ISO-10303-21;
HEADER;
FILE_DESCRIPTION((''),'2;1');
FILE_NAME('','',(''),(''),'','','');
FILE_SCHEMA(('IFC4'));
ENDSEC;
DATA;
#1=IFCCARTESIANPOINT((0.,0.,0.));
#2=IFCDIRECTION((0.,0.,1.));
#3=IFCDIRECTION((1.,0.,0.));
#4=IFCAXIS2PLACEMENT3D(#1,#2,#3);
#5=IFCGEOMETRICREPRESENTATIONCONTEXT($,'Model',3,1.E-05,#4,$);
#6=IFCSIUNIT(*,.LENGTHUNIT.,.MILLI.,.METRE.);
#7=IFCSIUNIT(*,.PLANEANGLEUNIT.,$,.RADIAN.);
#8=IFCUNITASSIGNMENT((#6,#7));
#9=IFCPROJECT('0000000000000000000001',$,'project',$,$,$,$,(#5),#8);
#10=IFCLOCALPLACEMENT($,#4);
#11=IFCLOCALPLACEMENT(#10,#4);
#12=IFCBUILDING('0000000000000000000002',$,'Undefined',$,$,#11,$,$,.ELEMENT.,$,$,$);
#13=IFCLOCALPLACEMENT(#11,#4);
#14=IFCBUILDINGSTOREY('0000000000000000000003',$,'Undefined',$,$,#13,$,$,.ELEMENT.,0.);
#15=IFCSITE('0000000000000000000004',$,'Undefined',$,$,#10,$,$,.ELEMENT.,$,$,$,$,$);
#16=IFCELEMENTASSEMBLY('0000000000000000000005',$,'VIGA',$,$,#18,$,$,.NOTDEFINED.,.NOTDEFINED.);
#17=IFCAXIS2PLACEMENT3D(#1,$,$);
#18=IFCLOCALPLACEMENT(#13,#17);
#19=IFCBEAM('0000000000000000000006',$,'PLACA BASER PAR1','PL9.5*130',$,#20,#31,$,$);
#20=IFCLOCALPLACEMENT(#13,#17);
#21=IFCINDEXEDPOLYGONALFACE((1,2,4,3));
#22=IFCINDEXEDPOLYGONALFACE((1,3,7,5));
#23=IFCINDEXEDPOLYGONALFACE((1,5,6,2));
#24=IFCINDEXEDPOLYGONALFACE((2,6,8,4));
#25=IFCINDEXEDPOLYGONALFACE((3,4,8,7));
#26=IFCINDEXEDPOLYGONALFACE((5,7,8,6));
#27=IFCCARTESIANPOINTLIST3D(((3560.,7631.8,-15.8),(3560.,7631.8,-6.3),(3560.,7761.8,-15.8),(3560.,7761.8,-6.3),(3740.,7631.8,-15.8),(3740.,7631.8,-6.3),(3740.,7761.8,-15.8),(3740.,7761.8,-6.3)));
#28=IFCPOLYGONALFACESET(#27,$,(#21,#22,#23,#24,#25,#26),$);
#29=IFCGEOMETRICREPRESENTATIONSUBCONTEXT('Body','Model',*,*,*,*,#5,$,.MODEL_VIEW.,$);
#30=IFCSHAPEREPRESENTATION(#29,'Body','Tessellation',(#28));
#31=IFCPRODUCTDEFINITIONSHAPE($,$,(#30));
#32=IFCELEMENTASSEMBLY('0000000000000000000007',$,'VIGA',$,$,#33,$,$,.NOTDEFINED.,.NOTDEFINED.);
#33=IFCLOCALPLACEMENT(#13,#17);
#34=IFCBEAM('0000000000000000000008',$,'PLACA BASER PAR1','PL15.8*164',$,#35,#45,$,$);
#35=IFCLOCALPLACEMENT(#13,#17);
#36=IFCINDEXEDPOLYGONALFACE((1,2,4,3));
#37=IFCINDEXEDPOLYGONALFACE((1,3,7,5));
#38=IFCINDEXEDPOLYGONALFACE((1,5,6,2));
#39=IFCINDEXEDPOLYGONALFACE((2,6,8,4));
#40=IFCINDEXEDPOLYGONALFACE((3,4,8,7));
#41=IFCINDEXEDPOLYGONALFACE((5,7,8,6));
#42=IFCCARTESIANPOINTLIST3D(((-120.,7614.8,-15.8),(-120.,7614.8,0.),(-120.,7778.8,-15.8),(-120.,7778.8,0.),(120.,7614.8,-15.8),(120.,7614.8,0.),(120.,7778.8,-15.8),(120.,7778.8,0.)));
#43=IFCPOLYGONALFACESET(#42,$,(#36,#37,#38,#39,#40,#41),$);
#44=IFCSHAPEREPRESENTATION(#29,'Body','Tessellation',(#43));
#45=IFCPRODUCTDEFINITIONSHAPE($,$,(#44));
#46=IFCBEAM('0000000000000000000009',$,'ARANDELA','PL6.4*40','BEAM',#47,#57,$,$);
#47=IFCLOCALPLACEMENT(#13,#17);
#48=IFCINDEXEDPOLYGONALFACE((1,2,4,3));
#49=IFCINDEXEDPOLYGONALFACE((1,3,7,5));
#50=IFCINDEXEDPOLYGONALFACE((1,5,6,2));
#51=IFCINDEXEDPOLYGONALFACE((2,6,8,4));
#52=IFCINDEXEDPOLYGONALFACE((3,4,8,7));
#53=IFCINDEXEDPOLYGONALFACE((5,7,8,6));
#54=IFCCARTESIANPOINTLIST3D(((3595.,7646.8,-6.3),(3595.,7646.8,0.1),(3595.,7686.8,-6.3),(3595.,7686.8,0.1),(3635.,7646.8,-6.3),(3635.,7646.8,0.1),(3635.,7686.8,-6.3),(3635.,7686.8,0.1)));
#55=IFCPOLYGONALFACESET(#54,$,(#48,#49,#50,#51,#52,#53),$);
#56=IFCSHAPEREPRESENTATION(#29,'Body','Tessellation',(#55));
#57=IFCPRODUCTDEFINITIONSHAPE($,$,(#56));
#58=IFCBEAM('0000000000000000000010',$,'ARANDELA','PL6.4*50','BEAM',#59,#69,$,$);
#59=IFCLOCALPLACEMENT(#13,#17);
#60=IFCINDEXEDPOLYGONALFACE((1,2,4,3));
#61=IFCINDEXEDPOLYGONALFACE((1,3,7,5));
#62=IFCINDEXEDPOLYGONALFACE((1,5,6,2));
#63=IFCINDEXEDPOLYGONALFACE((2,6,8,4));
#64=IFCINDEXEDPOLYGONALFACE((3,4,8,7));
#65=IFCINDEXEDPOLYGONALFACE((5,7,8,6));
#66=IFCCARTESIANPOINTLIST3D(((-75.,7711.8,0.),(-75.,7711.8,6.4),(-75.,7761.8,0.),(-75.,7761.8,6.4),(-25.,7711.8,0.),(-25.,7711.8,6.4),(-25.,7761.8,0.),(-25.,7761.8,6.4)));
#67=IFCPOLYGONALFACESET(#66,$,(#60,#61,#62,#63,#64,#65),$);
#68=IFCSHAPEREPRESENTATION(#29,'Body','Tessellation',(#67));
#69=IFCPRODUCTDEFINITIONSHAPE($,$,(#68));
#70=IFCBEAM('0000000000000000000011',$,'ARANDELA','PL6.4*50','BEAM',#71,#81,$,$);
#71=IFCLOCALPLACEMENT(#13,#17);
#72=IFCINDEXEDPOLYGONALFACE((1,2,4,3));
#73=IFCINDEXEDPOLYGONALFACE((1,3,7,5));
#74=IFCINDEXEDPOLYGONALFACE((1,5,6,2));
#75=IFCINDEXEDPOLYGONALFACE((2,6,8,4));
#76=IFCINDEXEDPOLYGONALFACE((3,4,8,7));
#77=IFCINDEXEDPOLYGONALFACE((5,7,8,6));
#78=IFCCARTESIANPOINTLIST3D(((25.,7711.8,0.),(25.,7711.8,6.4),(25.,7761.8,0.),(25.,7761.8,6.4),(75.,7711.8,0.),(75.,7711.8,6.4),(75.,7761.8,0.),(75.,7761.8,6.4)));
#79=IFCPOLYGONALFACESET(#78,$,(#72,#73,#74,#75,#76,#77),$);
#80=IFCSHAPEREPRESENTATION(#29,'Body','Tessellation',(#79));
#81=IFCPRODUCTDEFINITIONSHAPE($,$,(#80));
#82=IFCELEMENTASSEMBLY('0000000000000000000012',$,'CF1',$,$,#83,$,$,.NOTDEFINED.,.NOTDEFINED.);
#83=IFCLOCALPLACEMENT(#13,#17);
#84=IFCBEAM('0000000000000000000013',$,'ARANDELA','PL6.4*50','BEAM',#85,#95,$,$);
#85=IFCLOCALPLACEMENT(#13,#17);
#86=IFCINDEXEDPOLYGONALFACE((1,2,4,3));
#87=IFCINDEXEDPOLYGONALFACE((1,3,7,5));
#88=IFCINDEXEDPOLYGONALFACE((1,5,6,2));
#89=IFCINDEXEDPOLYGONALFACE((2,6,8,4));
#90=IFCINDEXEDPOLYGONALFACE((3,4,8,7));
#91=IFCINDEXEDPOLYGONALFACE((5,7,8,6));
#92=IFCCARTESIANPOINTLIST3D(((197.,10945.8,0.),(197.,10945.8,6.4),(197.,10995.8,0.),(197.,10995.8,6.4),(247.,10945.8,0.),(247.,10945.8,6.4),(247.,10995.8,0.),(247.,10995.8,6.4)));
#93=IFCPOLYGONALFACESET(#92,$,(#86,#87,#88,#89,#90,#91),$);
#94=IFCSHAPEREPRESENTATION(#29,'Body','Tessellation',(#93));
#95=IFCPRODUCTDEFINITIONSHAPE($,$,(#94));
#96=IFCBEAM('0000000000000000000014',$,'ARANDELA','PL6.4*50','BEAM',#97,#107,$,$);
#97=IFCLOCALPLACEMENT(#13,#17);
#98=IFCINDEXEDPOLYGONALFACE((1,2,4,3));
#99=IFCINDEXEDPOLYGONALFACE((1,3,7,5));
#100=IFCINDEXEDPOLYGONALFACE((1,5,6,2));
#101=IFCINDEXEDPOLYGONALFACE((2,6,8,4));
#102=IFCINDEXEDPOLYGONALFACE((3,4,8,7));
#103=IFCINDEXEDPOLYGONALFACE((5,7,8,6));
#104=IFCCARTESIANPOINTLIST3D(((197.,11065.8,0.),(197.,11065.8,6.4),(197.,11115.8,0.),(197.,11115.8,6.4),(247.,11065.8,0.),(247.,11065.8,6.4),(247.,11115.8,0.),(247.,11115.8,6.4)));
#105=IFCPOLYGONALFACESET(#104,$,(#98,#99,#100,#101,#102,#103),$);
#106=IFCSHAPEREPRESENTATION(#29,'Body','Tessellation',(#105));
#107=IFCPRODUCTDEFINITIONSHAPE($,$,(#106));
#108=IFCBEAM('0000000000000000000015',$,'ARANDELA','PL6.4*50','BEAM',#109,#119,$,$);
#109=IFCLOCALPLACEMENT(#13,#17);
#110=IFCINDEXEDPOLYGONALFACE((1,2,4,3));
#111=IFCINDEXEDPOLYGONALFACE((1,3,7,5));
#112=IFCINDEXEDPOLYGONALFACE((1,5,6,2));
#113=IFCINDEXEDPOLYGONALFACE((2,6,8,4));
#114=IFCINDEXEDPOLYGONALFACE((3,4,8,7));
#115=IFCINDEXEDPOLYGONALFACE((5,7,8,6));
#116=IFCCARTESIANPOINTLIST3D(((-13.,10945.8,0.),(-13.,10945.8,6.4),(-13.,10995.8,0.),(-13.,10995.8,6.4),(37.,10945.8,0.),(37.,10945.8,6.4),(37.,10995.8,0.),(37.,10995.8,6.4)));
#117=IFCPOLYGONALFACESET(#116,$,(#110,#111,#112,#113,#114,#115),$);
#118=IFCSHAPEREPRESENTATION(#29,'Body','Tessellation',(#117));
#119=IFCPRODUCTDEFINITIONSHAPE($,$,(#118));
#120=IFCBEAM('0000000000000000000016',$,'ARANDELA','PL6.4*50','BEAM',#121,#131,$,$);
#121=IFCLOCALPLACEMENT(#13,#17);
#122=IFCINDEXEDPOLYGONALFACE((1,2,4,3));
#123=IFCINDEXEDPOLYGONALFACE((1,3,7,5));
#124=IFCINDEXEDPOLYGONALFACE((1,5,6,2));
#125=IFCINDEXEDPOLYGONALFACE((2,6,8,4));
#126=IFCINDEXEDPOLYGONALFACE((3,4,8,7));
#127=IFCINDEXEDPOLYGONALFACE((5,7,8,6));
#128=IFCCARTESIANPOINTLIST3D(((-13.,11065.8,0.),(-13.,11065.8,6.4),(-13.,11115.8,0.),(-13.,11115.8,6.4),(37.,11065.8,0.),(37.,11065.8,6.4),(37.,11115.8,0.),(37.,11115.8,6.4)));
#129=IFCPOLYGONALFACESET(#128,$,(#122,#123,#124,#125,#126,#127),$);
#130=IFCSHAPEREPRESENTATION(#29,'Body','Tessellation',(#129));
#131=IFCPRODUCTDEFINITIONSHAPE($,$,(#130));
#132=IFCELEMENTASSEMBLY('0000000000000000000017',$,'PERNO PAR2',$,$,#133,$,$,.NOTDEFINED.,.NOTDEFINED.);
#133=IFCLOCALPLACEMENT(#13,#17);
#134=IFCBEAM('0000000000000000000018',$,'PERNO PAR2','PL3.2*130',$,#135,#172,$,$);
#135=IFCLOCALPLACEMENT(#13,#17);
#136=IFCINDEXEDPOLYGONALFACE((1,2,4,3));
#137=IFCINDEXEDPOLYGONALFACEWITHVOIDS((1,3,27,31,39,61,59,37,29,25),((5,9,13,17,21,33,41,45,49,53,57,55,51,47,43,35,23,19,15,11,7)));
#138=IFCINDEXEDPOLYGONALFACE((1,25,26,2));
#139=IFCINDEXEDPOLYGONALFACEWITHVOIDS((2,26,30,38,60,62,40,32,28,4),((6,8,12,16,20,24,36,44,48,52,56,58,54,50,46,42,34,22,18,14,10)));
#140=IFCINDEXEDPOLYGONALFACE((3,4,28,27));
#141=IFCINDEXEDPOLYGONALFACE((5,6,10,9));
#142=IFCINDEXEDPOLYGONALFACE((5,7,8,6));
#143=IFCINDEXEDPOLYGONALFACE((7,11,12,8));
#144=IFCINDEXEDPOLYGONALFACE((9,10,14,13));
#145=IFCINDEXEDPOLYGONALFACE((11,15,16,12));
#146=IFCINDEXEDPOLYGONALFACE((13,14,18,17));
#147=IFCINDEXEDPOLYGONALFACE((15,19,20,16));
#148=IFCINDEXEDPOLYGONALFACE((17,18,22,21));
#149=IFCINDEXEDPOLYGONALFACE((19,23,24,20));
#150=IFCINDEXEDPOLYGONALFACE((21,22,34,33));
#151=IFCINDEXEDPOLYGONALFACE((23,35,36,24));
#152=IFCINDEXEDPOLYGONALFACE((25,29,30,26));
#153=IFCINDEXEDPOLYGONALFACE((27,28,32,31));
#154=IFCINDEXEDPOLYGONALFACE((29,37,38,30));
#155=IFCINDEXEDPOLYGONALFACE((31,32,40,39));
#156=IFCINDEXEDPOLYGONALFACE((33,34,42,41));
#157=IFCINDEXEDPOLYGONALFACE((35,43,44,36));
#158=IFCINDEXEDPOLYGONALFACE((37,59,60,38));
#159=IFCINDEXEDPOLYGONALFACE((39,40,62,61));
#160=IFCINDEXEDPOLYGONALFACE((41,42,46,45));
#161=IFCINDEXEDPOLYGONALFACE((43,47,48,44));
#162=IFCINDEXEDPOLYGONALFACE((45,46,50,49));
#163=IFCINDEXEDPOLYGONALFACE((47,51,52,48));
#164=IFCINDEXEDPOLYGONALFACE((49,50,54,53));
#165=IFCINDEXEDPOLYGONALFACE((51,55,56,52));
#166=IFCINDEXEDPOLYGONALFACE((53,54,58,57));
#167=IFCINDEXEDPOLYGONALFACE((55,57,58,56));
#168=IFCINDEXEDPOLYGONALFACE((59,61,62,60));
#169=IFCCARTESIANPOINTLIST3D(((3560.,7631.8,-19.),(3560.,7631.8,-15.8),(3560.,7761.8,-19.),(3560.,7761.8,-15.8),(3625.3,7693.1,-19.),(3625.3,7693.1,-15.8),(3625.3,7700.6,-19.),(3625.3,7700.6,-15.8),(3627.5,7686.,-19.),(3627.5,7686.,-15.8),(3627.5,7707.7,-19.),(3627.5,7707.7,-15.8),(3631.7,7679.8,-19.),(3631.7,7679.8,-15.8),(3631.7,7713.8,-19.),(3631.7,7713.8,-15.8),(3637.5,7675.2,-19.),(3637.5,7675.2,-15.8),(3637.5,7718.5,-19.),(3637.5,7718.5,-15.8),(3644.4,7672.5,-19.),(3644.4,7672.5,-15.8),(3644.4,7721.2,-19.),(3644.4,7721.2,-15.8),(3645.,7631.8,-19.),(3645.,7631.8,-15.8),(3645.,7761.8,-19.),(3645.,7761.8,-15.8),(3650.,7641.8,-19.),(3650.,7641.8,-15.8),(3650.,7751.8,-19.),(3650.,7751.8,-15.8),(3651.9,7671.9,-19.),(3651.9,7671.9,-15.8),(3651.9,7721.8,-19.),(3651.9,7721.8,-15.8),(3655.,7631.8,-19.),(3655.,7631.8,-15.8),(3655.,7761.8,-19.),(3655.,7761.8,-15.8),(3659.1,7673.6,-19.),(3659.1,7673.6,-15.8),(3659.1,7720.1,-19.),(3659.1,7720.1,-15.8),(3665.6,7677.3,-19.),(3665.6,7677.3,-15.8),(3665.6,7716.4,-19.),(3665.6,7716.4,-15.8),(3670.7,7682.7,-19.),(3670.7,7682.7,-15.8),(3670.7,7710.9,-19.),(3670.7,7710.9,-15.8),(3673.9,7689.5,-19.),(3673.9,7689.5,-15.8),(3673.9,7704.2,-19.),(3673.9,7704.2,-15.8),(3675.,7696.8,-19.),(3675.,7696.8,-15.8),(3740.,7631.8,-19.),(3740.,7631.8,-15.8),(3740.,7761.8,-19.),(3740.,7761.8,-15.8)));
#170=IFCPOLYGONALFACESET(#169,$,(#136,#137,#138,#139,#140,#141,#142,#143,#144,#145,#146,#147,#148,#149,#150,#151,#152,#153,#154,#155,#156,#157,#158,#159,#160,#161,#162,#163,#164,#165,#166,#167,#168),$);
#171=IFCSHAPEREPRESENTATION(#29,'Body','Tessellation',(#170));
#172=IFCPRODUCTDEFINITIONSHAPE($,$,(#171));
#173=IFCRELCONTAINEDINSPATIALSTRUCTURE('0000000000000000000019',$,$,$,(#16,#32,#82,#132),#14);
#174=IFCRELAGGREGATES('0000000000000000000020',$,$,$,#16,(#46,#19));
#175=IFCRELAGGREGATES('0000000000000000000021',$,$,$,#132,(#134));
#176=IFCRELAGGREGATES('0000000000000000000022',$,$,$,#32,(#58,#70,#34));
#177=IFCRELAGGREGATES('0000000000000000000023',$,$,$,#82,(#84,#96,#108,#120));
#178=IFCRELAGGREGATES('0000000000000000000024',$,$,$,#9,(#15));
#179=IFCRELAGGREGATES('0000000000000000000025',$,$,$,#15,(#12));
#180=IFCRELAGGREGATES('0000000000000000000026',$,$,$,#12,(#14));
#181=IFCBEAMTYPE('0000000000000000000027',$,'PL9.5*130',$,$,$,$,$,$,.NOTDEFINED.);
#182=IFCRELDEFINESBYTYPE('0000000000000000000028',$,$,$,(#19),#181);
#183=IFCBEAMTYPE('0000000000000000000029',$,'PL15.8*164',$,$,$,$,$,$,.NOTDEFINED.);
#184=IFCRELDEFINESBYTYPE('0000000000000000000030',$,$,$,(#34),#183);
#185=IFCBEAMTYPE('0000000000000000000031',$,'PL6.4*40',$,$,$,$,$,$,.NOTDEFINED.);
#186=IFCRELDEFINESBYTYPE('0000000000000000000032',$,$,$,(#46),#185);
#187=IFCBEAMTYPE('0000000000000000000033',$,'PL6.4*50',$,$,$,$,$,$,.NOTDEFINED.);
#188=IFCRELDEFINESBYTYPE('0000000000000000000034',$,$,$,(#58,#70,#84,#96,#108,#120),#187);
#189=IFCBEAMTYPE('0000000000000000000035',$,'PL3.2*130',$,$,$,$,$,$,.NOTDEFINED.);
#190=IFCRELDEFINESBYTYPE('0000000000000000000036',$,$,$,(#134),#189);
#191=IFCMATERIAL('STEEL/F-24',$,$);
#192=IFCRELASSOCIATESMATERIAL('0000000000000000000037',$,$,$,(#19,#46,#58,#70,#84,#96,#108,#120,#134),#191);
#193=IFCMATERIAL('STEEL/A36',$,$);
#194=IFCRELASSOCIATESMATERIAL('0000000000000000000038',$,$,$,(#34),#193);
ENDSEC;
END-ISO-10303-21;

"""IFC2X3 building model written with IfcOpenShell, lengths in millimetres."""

from ifc_helpers import new_model, si_unit, frame, frame_2d, origin_with_axes, origin_2d_with_axis, place, context, subcontext, project, spatial, polyline, circle_curve, parameter, trimmed, segment, composite_curve, rectangle, outline, extrude, boolean, material, type_object, element, aggregate, save


model = new_model("IFC2X3")

# Units and contexts
model_context = context("Model", 3, precision=1e-05, world=origin_with_axes())
body_context = subcontext(model_context, "Body", "Model", "MODEL_VIEW")
ifc_project = project(units=[si_unit("LENGTHUNIT", "METRE", prefix="MILLI"), si_unit("PLANEANGLEUNIT", "RADIAN")], contexts=[model_context])

# Site, building, storey
site_placement = place(None, origin_with_axes())
site = spatial("IfcSite", under=ifc_project, at=site_placement, Name="Undefined", CompositionType="ELEMENT")
building_placement = place(site_placement, origin_with_axes())
building = spatial("IfcBuilding", under=site, at=building_placement, Name="Undefined", CompositionType="ELEMENT")
storey_placement = place(building_placement, origin_with_axes())
storey = spatial("IfcBuildingStorey", under=building, at=storey_placement, Name="Undefined", CompositionType="ELEMENT", Elevation=0.0)

# Element assemblies, beams
assembly_1_placement = place(storey_placement, origin_with_axes())
assembly_1 = element("IfcElementAssembly", 1, at=assembly_1_placement, inside=storey, Name="VIGA", AssemblyPlace="NOTDEFINED", PredefinedType="NOTDEFINED")
ifc_material_1 = material(Name="STEEL/F-24")
beam_type_1 = type_object("IfcBeamType", Name="PL9.5*130", PredefinedType="NOTDEFINED")
beam_1_placement = place(assembly_1_placement, frame((3560.0, 7696.8, -11.1), z_axis=(0.0, -1.0, 0.0), x_axis=(1.0, 0.0, 0.0)))
beam_1 = element("IfcBeam", 2, at=beam_1_placement, type_object=beam_type_1, material=ifc_material_1, Name="PLACA BASER PAR1", Description="PL9.5*130", context=body_context, shape_type="SweptSolid", body=[
    extrude(rectangle(XDim=9.5, YDim=130.0, at=origin_2d_with_axis()), frame((180.0, 0.0, 0.0), z_axis=(-1.0, 0.0, 0.0), x_axis=(0.0, -1.0, 0.0)), (0.0, 0.0, 1.0), 180.0),
])
assembly_2_placement = place(storey_placement, origin_with_axes())
assembly_2 = element("IfcElementAssembly", 3, at=assembly_2_placement, inside=storey, Name="VIGA", AssemblyPlace="NOTDEFINED", PredefinedType="NOTDEFINED")
ifc_material_2 = material(Name="STEEL/A36")
beam_type_2 = type_object("IfcBeamType", Name="PL15.8*164", PredefinedType="NOTDEFINED")
beam_2_placement = place(assembly_2_placement, frame((-120.0, 7696.8, -7.9), z_axis=(0.0, -1.0, 0.0), x_axis=(1.0, 0.0, 0.0)))
beam_2 = element("IfcBeam", 4, at=beam_2_placement, type_object=beam_type_2, material=ifc_material_2, Name="PLACA BASER PAR1", Description="PL15.8*164", context=body_context, shape_type="SweptSolid", body=[
    extrude(rectangle(XDim=15.8, YDim=164.0, at=origin_2d_with_axis()), frame((240.0, 0.0, 0.0), z_axis=(-1.0, 0.0, 0.0), x_axis=(0.0, -1.0, 0.0)), (0.0, 0.0, 1.0), 240.0),
])

# Beams
beam_type_3 = type_object("IfcBeamType", Name="PL6.4*40", PredefinedType="NOTDEFINED")
beam_3_placement = place(assembly_1_placement, frame((3595.0, 7666.8, -3.1), z_axis=(0.0, 1.0, 0.0), x_axis=(1.0, 0.0, 0.0)))
beam_3 = element("IfcBeam", 5, at=beam_3_placement, type_object=beam_type_3, material=ifc_material_1, Name="ARANDELA", Description="PL6.4*40", ObjectType="BEAM", context=body_context, shape_type="SweptSolid", body=[
    extrude(rectangle(XDim=6.4, YDim=40.0, at=origin_2d_with_axis()), frame((40.0, 0.0, 0.0), z_axis=(-1.0, 0.0, 0.0), x_axis=(0.0, -1.0, 0.0)), (0.0, 0.0, 1.0), 40.0),
])
aggregate(assembly_1, [beam_3, beam_1])
beam_type_4 = type_object("IfcBeamType", Name="PL6.4*50", PredefinedType="NOTDEFINED")
beam_4_placement = place(assembly_2_placement, frame((-75.0, 7736.8, 3.2), z_axis=(0.0, 1.0, 0.0), x_axis=(1.0, 0.0, 0.0)))
beam_4 = element("IfcBeam", 6, at=beam_4_placement, type_object=beam_type_4, material=ifc_material_1, Name="ARANDELA", Description="PL6.4*50", ObjectType="BEAM", context=body_context, shape_type="SweptSolid", body=[
    extrude(rectangle(XDim=6.4, YDim=50.0, at=origin_2d_with_axis()), frame((50.0, 0.0, 0.0), z_axis=(-1.0, 0.0, 0.0), x_axis=(0.0, -1.0, 0.0)), (0.0, 0.0, 1.0), 50.0),
])
beam_5_placement = place(assembly_2_placement, frame((25.0, 7736.8, 3.2), z_axis=(0.0, 1.0, 0.0), x_axis=(1.0, 0.0, 0.0)))
beam_5 = element("IfcBeam", 7, at=beam_5_placement, type_object=beam_type_4, material=ifc_material_1, Name="ARANDELA", Description="PL6.4*50", ObjectType="BEAM", context=body_context, shape_type="SweptSolid", body=[
    extrude(rectangle(XDim=6.4, YDim=50.0, at=origin_2d_with_axis()), frame((50.0, 0.0, 0.0), z_axis=(-1.0, 0.0, 0.0), x_axis=(0.0, -1.0, 0.0)), (0.0, 0.0, 1.0), 50.0),
])

# Element assembly, beams
assembly_3_placement = place(storey_placement, origin_with_axes())
assembly_3 = element("IfcElementAssembly", 8, at=assembly_3_placement, inside=storey, Name="CF1", AssemblyPlace="NOTDEFINED", PredefinedType="NOTDEFINED")
beam_6_placement = place(assembly_3_placement, frame((197.0, 10970.8, 3.2), z_axis=(0.0, 1.0, 0.0), x_axis=(1.0, 0.0, 0.0)))
beam_6 = element("IfcBeam", 9, at=beam_6_placement, type_object=beam_type_4, material=ifc_material_1, Name="ARANDELA", Description="PL6.4*50", ObjectType="BEAM", context=body_context, shape_type="SweptSolid", body=[
    extrude(rectangle(XDim=6.4, YDim=50.0, at=origin_2d_with_axis()), frame((50.0, 0.0, 0.0), z_axis=(-1.0, 0.0, 0.0), x_axis=(0.0, -1.0, 0.0)), (0.0, 0.0, 1.0), 50.0),
])
beam_7_placement = place(assembly_3_placement, frame((197.0, 11090.8, 3.2), z_axis=(0.0, 1.0, 0.0), x_axis=(1.0, 0.0, 0.0)))
beam_7 = element("IfcBeam", 10, at=beam_7_placement, type_object=beam_type_4, material=ifc_material_1, Name="ARANDELA", Description="PL6.4*50", ObjectType="BEAM", context=body_context, shape_type="SweptSolid", body=[
    extrude(rectangle(XDim=6.4, YDim=50.0, at=origin_2d_with_axis()), frame((50.0, 0.0, 0.0), z_axis=(-1.0, 0.0, 0.0), x_axis=(0.0, -1.0, 0.0)), (0.0, 0.0, 1.0), 50.0),
])
beam_8_placement = place(assembly_3_placement, frame((-13.0, 10970.8, 3.2), z_axis=(0.0, 1.0, 0.0), x_axis=(1.0, 0.0, 0.0)))
beam_8 = element("IfcBeam", 11, at=beam_8_placement, type_object=beam_type_4, material=ifc_material_1, Name="ARANDELA", Description="PL6.4*50", ObjectType="BEAM", context=body_context, shape_type="SweptSolid", body=[
    extrude(rectangle(XDim=6.4, YDim=50.0, at=origin_2d_with_axis()), frame((50.0, 0.0, 0.0), z_axis=(-1.0, 0.0, 0.0), x_axis=(0.0, -1.0, 0.0)), (0.0, 0.0, 1.0), 50.0),
])
beam_9_placement = place(assembly_3_placement, frame((-13.0, 11090.8, 3.2), z_axis=(0.0, 1.0, 0.0), x_axis=(1.0, 0.0, 0.0)))
beam_9 = element("IfcBeam", 12, at=beam_9_placement, type_object=beam_type_4, material=ifc_material_1, Name="ARANDELA", Description="PL6.4*50", ObjectType="BEAM", context=body_context, shape_type="SweptSolid", body=[
    extrude(rectangle(XDim=6.4, YDim=50.0, at=origin_2d_with_axis()), frame((50.0, 0.0, 0.0), z_axis=(-1.0, 0.0, 0.0), x_axis=(0.0, -1.0, 0.0)), (0.0, 0.0, 1.0), 50.0),
])

# Element assembly, beam
assembly_4_placement = place(storey_placement, origin_with_axes())
assembly_4 = element("IfcElementAssembly", 13, at=assembly_4_placement, inside=storey, Name="PERNO PAR2", AssemblyPlace="NOTDEFINED", PredefinedType="NOTDEFINED")
beam_type_5 = type_object("IfcBeamType", Name="PL3.2*130", PredefinedType="NOTDEFINED")
beam_10_placement = place(assembly_4_placement, frame((3560.0, 7696.8, -17.4), z_axis=(0.0, -1.0, 0.0), x_axis=(1.0, 0.0, 0.0)))
beam_10 = element("IfcBeam", 14, at=beam_10_placement, type_object=beam_type_5, material=ifc_material_1, Name="PERNO PAR2", Description="PL3.2*130", context=body_context, shape_type="CSG", body=[
    boolean("DIFFERENCE", boolean("DIFFERENCE", boolean("DIFFERENCE", extrude(rectangle(XDim=3.2, YDim=130.0, at=origin_2d_with_axis()), frame((180.0, 0.0, 0.0), z_axis=(-1.0, 0.0, 0.0), x_axis=(0.0, -1.0, 0.0)), (0.0, 0.0, 1.0), 180.0), extrude(outline(composite_curve([segment(trimmed(circle_curve(frame_2d((25.0, 25.0), x_axis=(-1.0, 0.0)), 25.0), [parameter(0.0)], [parameter(1.570796)], True, "PARAMETER"), True, "CONTINUOUS"), segment(polyline([(25.0, 0.0), (25.0, 0.0)]), True, "CONTINUOUS"), segment(trimmed(circle_curve(frame_2d((25.0, 25.0), x_axis=(0.0, -1.0)), 25.0), [parameter(0.0)], [parameter(1.570796)], True, "PARAMETER"), True, "CONTINUOUS"), segment(polyline([(50.0, 25.0), (50.0, 25.0)]), True, "CONTINUOUS"), segment(trimmed(circle_curve(frame_2d((25.0, 25.0), x_axis=(1.0, 0.0)), 25.0), [parameter(0.0)], [parameter(1.570796)], True, "PARAMETER"), True, "CONTINUOUS"), segment(polyline([(25.0, 50.0), (25.0, 50.0)]), True, "CONTINUOUS"), segment(trimmed(circle_curve(frame_2d((25.0, 25.0), x_axis=(0.0, 1.0)), 25.0), [parameter(0.0)], [parameter(1.570796)], True, "PARAMETER"), True, "CONTINUOUS"), segment(polyline([(0.0, 25.0), (0.0, 25.0)]), True, "CONTINUOUS")], self_intersect=True)), frame((65.0, -4.5, 25.0), z_axis=(0.0, 1.0, 0.0), x_axis=(1.0, 0.0, 0.0)), (0.0, 0.0, 1.0), 9.0)), extrude(outline(polyline([(0.0, 0.0), (10.0, 0.0), (5.0, 10.0), (0.0, 0.0)])), frame((85.0, -4.5, 65.0), z_axis=(0.0, 1.0, 0.0), x_axis=(1.0, 0.0, 0.0)), (0.0, 0.0, 1.0), 9.0)), extrude(outline(polyline([(0.0, 0.0), (10.0, 0.0), (5.0, 10.0), (0.0, 0.0)])), frame((85.0, 4.5, -65.0), z_axis=(0.0, -1.0, 0.0), x_axis=(1.0, 0.0, 0.0)), (0.0, 0.0, 1.0), 9.0)),
])
aggregate(assembly_4, [beam_10])

aggregate(assembly_2, [beam_4, beam_5, beam_2])

aggregate(assembly_3, [beam_6, beam_7, beam_8, beam_9])

save(model, "model.ifc")
